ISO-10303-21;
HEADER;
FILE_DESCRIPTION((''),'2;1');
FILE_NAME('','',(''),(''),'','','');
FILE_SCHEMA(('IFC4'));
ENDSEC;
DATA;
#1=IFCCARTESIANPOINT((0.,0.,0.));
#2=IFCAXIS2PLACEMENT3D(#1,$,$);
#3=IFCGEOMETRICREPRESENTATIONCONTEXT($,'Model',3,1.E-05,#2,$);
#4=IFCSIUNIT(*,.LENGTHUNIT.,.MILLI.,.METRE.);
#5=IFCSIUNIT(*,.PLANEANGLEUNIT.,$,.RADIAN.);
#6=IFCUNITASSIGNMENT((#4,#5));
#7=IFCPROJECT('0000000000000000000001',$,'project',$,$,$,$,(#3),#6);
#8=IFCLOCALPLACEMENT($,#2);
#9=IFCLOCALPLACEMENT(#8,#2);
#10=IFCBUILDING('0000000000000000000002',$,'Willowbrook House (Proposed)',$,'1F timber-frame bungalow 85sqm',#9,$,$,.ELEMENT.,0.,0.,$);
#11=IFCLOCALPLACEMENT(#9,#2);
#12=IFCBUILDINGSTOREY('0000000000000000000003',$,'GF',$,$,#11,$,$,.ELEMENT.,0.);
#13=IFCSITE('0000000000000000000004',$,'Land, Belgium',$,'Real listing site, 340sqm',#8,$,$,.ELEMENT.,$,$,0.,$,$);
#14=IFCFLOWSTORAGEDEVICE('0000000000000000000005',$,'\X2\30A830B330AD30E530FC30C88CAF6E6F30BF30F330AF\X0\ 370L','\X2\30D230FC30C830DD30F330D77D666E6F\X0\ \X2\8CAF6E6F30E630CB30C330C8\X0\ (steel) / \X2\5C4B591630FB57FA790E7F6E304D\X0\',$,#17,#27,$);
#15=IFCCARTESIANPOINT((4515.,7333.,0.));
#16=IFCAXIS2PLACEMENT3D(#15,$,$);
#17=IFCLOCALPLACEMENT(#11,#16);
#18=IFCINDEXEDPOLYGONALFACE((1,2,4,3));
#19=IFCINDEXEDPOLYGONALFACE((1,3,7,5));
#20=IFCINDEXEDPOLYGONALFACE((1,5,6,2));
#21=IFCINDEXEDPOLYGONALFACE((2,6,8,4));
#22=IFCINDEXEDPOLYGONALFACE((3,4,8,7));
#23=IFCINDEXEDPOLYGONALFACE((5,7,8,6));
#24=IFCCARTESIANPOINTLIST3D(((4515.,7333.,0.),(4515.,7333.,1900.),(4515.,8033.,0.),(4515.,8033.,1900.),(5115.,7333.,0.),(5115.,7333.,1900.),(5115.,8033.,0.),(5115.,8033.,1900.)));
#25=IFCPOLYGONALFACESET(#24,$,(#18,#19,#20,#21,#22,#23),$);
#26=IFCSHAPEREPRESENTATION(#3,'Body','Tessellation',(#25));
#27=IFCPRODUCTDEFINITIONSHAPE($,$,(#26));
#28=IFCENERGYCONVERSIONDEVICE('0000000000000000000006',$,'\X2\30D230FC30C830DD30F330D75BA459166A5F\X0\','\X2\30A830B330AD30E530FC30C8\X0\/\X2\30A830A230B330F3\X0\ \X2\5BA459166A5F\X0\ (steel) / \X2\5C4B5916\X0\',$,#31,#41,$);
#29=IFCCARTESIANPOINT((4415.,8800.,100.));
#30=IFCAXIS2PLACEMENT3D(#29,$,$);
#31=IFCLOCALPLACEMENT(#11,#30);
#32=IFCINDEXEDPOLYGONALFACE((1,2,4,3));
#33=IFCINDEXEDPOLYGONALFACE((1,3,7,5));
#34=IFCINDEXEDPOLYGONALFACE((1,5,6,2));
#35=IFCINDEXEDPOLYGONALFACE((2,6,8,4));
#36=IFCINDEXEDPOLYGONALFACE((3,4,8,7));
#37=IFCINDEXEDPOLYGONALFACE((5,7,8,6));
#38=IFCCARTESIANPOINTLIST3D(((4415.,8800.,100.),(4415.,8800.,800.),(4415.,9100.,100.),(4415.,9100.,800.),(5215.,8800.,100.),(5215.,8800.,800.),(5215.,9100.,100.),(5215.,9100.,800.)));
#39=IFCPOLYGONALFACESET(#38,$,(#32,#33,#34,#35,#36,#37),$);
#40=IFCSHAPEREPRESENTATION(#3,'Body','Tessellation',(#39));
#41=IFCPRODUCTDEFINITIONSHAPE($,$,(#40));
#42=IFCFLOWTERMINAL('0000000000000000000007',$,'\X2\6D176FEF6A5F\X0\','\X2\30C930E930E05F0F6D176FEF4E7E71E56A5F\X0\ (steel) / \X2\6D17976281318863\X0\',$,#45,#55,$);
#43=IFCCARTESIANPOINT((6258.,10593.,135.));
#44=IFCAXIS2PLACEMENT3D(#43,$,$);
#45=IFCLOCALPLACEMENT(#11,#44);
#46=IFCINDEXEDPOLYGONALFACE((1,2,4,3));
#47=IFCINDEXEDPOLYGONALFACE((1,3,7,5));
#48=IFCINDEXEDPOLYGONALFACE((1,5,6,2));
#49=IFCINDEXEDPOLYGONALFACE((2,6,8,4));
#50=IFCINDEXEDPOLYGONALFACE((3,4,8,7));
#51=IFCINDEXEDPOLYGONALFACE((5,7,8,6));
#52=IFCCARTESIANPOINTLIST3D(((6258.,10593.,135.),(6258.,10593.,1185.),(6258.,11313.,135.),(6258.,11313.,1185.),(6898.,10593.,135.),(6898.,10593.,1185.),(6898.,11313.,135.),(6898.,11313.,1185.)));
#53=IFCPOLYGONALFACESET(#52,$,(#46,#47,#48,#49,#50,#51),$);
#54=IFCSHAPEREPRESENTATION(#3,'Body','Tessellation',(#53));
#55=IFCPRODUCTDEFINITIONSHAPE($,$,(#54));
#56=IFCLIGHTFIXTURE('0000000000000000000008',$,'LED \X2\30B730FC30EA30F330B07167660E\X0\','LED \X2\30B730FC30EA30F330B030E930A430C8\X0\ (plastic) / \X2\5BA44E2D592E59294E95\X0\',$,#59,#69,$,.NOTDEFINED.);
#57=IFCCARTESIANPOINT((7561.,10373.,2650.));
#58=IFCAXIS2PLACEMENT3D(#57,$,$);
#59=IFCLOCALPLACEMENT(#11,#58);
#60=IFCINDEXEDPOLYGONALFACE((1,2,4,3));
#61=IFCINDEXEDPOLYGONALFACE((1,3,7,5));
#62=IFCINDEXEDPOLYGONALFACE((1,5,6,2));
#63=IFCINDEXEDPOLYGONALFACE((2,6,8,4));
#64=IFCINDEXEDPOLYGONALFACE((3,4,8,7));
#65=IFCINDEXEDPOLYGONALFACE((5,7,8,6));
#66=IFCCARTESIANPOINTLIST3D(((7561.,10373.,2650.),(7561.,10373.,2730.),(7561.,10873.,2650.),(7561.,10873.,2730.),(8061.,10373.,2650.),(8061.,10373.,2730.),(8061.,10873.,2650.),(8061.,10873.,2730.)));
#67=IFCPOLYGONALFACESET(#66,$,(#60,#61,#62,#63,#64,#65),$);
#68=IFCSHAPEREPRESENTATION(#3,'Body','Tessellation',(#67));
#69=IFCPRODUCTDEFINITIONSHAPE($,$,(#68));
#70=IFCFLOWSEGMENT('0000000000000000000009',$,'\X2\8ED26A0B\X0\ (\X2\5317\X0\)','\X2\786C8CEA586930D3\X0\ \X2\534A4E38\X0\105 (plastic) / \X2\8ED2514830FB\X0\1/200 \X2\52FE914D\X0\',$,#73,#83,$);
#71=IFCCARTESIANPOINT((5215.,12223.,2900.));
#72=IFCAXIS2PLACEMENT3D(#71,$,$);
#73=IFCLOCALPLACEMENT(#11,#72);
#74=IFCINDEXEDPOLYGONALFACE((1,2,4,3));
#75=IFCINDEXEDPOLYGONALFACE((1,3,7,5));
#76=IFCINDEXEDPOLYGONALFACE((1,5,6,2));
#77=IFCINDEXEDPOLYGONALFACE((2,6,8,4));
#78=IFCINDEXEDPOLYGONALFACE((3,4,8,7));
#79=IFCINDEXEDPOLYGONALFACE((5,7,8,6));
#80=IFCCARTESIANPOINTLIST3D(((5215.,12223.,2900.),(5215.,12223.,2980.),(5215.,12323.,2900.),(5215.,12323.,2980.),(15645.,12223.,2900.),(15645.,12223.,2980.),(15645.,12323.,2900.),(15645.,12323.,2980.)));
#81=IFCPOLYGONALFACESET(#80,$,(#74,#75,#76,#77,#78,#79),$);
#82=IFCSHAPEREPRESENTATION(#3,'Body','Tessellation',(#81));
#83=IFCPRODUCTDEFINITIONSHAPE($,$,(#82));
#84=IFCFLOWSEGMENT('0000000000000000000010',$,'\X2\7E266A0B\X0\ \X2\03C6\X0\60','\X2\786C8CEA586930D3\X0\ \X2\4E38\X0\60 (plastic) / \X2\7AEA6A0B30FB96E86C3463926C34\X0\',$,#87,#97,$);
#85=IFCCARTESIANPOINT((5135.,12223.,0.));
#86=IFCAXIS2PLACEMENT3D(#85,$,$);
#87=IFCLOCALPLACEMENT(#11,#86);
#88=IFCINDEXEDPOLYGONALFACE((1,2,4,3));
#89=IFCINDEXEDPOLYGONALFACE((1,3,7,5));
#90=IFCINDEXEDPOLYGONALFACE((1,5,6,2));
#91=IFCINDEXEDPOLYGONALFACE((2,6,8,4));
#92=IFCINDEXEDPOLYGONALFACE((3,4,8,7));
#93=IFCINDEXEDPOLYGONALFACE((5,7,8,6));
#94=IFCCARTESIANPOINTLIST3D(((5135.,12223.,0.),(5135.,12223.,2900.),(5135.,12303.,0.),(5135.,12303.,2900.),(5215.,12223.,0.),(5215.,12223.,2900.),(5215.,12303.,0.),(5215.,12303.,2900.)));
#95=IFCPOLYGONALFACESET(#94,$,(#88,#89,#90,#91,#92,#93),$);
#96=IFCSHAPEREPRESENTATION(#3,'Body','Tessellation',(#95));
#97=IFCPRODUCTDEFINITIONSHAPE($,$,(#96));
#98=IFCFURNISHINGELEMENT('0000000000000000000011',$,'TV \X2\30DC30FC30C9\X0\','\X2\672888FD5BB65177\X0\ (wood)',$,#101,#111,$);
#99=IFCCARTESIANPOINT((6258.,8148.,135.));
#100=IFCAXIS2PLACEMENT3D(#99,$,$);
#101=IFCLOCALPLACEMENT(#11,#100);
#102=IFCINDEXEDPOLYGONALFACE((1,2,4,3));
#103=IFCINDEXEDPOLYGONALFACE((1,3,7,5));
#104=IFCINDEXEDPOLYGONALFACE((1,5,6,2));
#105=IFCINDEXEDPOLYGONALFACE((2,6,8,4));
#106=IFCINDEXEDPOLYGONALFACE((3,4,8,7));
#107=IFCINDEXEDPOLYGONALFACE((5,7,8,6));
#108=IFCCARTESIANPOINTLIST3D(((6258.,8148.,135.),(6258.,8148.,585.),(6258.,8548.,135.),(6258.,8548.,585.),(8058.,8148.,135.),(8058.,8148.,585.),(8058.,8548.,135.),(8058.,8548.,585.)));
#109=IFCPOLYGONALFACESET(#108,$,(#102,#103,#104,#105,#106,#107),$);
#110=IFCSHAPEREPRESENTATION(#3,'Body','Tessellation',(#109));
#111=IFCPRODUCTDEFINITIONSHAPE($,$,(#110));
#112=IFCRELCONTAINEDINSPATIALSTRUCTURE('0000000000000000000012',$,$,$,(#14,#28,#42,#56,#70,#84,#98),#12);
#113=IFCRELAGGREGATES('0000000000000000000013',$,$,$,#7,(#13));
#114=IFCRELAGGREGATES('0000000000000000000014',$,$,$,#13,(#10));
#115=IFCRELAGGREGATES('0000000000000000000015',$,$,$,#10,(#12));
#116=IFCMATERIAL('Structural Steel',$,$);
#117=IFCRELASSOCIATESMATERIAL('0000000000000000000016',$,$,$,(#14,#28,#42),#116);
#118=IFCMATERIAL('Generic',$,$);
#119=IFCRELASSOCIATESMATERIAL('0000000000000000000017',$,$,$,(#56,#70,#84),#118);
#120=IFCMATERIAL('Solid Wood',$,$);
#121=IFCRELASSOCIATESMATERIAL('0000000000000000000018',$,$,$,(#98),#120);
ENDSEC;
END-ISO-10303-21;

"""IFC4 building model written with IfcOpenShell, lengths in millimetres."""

from ifc_helpers import new_model, si_unit, frame, frame_2d, origin, place, context, project, spatial, rectangle, extrude, material, element, save


model = new_model("IFC4")

# Units and contexts
model_context = context("Model", 3, precision=1e-05, world=origin())
ifc_project = project(units=[si_unit("LENGTHUNIT", "METRE", prefix="MILLI"), si_unit("PLANEANGLEUNIT", "RADIAN")], contexts=[model_context])

# Site, building, storey
site_placement = place(None, origin())
site = spatial("IfcSite", under=ifc_project, at=site_placement, Name="Land, Belgium", ObjectType="Real listing site, 340sqm", CompositionType="ELEMENT", RefElevation=0.0)
building_placement = place(site_placement, origin())
building = spatial("IfcBuilding", under=site, at=building_placement, Name="Willowbrook House (Proposed)", ObjectType="1F timber-frame bungalow 85sqm", CompositionType="ELEMENT", ElevationOfRefHeight=0.0, ElevationOfTerrain=0.0)
storey_placement = place(building_placement, origin())
storey = spatial("IfcBuildingStorey", under=building, at=storey_placement, Name="GF", CompositionType="ELEMENT", Elevation=0.0)

# Shared definitions
ifc_material_1 = material(Name="Solid Wood")

# Shared definitions
ifc_material_2 = material(Name="Structural Steel")

# Shared definitions
ifc_material_3 = material(Name="Generic")

# Flow storage device
flow_storage_device_placement = place(storey_placement, frame((4515.0, 7333.0, 0.0)))
element("IfcFlowStorageDevice", 1, at=flow_storage_device_placement, inside=storey, material=ifc_material_2, Name="エコキュート貯湯タンク 370L", Description="ヒートポンプ給湯 貯湯ユニット (steel) / 屋外・基礎置き", context=model_context, shape_type="SweptSolid", body=[
    extrude(rectangle(XDim=600.0, YDim=700.0, at=frame_2d((300.0, 350.0))), frame((4515.0, 7333.0, 0.0)), (0.0, 0.0, 1.0), 1900.0),
])

# Energy conversion device
energy_conversion_device_placement = place(storey_placement, frame((4415.0, 8800.0, 100.0)))
element("IfcEnergyConversionDevice", 2, at=energy_conversion_device_placement, inside=storey, material=ifc_material_2, Name="ヒートポンプ室外機", Description="エコキュート/エアコン 室外機 (steel) / 屋外", context=model_context, shape_type="SweptSolid", body=[
    extrude(rectangle(XDim=800.0, YDim=300.0, at=frame_2d((400.0, 150.0))), frame((4415.0, 8800.0, 100.0)), (0.0, 0.0, 1.0), 700.0),
])

# Flow terminal
flow_terminal_placement = place(storey_placement, frame((6258.0, 10593.0, 135.0)))
element("IfcFlowTerminal", 3, at=flow_terminal_placement, inside=storey, material=ifc_material_2, Name="洗濯機", Description="ドラム式洗濯乾燥機 (steel) / 洗面脱衣", context=model_context, shape_type="SweptSolid", body=[
    extrude(rectangle(XDim=640.0, YDim=720.0, at=frame_2d((320.0, 360.0))), frame((6258.0, 10593.0, 135.0)), (0.0, 0.0, 1.0), 1050.0),
])

# Light fixture
light_fixture_placement = place(storey_placement, frame((7561.0, 10373.0, 2650.0)))
element("IfcLightFixture", 4, at=light_fixture_placement, inside=storey, material=ifc_material_3, Name="LED シーリング照明", Description="LED シーリングライト (plastic) / 室中央天井", PredefinedType="NOTDEFINED", context=model_context, shape_type="SweptSolid", body=[
    extrude(rectangle(XDim=500.0, YDim=500.0, at=frame_2d((250.0, 250.0))), frame((7561.0, 10373.0, 2650.0)), (0.0, 0.0, 1.0), 80.0),
])

# Flow segments
flow_segment_1_placement = place(storey_placement, frame((5215.0, 12223.0, 2900.0)))
element("IfcFlowSegment", 5, at=flow_segment_1_placement, inside=storey, material=ifc_material_3, Name="軒樋 (北)", Description="硬質塩ビ 半丸105 (plastic) / 軒先・1/200 勾配", context=model_context, shape_type="SweptSolid", body=[
    extrude(rectangle(XDim=10430.0, YDim=100.0, at=frame_2d((5215.0, 50.0))), frame((5215.0, 12223.0, 2900.0)), (0.0, 0.0, 1.0), 80.0),
])
flow_segment_2_placement = place(storey_placement, frame((5135.0, 12223.0, 0.0)))
element("IfcFlowSegment", 6, at=flow_segment_2_placement, inside=storey, material=ifc_material_3, Name="縦樋 φ60", Description="硬質塩ビ 丸60 (plastic) / 竪樋・雨水排水", context=model_context, shape_type="SweptSolid", body=[
    extrude(rectangle(XDim=80.0, YDim=80.0, at=frame_2d((40.0, 40.0))), frame((5135.0, 12223.0, 0.0)), (0.0, 0.0, 1.0), 2900.0),
])

# Furnishing element
furnishing_placement = place(storey_placement, frame((6258.0, 8148.0, 135.0)))
element("IfcFurnishingElement", 7, at=furnishing_placement, inside=storey, material=ifc_material_1, Name="TV ボード", Description="木製家具 (wood)", context=model_context, shape_type="SweptSolid", body=[
    extrude(rectangle(XDim=1800.0, YDim=400.0, at=frame_2d((900.0, 200.0))), frame((6258.0, 8148.0, 135.0)), (0.0, 0.0, 1.0), 450.0),
])

save(model, "model.ifc")
